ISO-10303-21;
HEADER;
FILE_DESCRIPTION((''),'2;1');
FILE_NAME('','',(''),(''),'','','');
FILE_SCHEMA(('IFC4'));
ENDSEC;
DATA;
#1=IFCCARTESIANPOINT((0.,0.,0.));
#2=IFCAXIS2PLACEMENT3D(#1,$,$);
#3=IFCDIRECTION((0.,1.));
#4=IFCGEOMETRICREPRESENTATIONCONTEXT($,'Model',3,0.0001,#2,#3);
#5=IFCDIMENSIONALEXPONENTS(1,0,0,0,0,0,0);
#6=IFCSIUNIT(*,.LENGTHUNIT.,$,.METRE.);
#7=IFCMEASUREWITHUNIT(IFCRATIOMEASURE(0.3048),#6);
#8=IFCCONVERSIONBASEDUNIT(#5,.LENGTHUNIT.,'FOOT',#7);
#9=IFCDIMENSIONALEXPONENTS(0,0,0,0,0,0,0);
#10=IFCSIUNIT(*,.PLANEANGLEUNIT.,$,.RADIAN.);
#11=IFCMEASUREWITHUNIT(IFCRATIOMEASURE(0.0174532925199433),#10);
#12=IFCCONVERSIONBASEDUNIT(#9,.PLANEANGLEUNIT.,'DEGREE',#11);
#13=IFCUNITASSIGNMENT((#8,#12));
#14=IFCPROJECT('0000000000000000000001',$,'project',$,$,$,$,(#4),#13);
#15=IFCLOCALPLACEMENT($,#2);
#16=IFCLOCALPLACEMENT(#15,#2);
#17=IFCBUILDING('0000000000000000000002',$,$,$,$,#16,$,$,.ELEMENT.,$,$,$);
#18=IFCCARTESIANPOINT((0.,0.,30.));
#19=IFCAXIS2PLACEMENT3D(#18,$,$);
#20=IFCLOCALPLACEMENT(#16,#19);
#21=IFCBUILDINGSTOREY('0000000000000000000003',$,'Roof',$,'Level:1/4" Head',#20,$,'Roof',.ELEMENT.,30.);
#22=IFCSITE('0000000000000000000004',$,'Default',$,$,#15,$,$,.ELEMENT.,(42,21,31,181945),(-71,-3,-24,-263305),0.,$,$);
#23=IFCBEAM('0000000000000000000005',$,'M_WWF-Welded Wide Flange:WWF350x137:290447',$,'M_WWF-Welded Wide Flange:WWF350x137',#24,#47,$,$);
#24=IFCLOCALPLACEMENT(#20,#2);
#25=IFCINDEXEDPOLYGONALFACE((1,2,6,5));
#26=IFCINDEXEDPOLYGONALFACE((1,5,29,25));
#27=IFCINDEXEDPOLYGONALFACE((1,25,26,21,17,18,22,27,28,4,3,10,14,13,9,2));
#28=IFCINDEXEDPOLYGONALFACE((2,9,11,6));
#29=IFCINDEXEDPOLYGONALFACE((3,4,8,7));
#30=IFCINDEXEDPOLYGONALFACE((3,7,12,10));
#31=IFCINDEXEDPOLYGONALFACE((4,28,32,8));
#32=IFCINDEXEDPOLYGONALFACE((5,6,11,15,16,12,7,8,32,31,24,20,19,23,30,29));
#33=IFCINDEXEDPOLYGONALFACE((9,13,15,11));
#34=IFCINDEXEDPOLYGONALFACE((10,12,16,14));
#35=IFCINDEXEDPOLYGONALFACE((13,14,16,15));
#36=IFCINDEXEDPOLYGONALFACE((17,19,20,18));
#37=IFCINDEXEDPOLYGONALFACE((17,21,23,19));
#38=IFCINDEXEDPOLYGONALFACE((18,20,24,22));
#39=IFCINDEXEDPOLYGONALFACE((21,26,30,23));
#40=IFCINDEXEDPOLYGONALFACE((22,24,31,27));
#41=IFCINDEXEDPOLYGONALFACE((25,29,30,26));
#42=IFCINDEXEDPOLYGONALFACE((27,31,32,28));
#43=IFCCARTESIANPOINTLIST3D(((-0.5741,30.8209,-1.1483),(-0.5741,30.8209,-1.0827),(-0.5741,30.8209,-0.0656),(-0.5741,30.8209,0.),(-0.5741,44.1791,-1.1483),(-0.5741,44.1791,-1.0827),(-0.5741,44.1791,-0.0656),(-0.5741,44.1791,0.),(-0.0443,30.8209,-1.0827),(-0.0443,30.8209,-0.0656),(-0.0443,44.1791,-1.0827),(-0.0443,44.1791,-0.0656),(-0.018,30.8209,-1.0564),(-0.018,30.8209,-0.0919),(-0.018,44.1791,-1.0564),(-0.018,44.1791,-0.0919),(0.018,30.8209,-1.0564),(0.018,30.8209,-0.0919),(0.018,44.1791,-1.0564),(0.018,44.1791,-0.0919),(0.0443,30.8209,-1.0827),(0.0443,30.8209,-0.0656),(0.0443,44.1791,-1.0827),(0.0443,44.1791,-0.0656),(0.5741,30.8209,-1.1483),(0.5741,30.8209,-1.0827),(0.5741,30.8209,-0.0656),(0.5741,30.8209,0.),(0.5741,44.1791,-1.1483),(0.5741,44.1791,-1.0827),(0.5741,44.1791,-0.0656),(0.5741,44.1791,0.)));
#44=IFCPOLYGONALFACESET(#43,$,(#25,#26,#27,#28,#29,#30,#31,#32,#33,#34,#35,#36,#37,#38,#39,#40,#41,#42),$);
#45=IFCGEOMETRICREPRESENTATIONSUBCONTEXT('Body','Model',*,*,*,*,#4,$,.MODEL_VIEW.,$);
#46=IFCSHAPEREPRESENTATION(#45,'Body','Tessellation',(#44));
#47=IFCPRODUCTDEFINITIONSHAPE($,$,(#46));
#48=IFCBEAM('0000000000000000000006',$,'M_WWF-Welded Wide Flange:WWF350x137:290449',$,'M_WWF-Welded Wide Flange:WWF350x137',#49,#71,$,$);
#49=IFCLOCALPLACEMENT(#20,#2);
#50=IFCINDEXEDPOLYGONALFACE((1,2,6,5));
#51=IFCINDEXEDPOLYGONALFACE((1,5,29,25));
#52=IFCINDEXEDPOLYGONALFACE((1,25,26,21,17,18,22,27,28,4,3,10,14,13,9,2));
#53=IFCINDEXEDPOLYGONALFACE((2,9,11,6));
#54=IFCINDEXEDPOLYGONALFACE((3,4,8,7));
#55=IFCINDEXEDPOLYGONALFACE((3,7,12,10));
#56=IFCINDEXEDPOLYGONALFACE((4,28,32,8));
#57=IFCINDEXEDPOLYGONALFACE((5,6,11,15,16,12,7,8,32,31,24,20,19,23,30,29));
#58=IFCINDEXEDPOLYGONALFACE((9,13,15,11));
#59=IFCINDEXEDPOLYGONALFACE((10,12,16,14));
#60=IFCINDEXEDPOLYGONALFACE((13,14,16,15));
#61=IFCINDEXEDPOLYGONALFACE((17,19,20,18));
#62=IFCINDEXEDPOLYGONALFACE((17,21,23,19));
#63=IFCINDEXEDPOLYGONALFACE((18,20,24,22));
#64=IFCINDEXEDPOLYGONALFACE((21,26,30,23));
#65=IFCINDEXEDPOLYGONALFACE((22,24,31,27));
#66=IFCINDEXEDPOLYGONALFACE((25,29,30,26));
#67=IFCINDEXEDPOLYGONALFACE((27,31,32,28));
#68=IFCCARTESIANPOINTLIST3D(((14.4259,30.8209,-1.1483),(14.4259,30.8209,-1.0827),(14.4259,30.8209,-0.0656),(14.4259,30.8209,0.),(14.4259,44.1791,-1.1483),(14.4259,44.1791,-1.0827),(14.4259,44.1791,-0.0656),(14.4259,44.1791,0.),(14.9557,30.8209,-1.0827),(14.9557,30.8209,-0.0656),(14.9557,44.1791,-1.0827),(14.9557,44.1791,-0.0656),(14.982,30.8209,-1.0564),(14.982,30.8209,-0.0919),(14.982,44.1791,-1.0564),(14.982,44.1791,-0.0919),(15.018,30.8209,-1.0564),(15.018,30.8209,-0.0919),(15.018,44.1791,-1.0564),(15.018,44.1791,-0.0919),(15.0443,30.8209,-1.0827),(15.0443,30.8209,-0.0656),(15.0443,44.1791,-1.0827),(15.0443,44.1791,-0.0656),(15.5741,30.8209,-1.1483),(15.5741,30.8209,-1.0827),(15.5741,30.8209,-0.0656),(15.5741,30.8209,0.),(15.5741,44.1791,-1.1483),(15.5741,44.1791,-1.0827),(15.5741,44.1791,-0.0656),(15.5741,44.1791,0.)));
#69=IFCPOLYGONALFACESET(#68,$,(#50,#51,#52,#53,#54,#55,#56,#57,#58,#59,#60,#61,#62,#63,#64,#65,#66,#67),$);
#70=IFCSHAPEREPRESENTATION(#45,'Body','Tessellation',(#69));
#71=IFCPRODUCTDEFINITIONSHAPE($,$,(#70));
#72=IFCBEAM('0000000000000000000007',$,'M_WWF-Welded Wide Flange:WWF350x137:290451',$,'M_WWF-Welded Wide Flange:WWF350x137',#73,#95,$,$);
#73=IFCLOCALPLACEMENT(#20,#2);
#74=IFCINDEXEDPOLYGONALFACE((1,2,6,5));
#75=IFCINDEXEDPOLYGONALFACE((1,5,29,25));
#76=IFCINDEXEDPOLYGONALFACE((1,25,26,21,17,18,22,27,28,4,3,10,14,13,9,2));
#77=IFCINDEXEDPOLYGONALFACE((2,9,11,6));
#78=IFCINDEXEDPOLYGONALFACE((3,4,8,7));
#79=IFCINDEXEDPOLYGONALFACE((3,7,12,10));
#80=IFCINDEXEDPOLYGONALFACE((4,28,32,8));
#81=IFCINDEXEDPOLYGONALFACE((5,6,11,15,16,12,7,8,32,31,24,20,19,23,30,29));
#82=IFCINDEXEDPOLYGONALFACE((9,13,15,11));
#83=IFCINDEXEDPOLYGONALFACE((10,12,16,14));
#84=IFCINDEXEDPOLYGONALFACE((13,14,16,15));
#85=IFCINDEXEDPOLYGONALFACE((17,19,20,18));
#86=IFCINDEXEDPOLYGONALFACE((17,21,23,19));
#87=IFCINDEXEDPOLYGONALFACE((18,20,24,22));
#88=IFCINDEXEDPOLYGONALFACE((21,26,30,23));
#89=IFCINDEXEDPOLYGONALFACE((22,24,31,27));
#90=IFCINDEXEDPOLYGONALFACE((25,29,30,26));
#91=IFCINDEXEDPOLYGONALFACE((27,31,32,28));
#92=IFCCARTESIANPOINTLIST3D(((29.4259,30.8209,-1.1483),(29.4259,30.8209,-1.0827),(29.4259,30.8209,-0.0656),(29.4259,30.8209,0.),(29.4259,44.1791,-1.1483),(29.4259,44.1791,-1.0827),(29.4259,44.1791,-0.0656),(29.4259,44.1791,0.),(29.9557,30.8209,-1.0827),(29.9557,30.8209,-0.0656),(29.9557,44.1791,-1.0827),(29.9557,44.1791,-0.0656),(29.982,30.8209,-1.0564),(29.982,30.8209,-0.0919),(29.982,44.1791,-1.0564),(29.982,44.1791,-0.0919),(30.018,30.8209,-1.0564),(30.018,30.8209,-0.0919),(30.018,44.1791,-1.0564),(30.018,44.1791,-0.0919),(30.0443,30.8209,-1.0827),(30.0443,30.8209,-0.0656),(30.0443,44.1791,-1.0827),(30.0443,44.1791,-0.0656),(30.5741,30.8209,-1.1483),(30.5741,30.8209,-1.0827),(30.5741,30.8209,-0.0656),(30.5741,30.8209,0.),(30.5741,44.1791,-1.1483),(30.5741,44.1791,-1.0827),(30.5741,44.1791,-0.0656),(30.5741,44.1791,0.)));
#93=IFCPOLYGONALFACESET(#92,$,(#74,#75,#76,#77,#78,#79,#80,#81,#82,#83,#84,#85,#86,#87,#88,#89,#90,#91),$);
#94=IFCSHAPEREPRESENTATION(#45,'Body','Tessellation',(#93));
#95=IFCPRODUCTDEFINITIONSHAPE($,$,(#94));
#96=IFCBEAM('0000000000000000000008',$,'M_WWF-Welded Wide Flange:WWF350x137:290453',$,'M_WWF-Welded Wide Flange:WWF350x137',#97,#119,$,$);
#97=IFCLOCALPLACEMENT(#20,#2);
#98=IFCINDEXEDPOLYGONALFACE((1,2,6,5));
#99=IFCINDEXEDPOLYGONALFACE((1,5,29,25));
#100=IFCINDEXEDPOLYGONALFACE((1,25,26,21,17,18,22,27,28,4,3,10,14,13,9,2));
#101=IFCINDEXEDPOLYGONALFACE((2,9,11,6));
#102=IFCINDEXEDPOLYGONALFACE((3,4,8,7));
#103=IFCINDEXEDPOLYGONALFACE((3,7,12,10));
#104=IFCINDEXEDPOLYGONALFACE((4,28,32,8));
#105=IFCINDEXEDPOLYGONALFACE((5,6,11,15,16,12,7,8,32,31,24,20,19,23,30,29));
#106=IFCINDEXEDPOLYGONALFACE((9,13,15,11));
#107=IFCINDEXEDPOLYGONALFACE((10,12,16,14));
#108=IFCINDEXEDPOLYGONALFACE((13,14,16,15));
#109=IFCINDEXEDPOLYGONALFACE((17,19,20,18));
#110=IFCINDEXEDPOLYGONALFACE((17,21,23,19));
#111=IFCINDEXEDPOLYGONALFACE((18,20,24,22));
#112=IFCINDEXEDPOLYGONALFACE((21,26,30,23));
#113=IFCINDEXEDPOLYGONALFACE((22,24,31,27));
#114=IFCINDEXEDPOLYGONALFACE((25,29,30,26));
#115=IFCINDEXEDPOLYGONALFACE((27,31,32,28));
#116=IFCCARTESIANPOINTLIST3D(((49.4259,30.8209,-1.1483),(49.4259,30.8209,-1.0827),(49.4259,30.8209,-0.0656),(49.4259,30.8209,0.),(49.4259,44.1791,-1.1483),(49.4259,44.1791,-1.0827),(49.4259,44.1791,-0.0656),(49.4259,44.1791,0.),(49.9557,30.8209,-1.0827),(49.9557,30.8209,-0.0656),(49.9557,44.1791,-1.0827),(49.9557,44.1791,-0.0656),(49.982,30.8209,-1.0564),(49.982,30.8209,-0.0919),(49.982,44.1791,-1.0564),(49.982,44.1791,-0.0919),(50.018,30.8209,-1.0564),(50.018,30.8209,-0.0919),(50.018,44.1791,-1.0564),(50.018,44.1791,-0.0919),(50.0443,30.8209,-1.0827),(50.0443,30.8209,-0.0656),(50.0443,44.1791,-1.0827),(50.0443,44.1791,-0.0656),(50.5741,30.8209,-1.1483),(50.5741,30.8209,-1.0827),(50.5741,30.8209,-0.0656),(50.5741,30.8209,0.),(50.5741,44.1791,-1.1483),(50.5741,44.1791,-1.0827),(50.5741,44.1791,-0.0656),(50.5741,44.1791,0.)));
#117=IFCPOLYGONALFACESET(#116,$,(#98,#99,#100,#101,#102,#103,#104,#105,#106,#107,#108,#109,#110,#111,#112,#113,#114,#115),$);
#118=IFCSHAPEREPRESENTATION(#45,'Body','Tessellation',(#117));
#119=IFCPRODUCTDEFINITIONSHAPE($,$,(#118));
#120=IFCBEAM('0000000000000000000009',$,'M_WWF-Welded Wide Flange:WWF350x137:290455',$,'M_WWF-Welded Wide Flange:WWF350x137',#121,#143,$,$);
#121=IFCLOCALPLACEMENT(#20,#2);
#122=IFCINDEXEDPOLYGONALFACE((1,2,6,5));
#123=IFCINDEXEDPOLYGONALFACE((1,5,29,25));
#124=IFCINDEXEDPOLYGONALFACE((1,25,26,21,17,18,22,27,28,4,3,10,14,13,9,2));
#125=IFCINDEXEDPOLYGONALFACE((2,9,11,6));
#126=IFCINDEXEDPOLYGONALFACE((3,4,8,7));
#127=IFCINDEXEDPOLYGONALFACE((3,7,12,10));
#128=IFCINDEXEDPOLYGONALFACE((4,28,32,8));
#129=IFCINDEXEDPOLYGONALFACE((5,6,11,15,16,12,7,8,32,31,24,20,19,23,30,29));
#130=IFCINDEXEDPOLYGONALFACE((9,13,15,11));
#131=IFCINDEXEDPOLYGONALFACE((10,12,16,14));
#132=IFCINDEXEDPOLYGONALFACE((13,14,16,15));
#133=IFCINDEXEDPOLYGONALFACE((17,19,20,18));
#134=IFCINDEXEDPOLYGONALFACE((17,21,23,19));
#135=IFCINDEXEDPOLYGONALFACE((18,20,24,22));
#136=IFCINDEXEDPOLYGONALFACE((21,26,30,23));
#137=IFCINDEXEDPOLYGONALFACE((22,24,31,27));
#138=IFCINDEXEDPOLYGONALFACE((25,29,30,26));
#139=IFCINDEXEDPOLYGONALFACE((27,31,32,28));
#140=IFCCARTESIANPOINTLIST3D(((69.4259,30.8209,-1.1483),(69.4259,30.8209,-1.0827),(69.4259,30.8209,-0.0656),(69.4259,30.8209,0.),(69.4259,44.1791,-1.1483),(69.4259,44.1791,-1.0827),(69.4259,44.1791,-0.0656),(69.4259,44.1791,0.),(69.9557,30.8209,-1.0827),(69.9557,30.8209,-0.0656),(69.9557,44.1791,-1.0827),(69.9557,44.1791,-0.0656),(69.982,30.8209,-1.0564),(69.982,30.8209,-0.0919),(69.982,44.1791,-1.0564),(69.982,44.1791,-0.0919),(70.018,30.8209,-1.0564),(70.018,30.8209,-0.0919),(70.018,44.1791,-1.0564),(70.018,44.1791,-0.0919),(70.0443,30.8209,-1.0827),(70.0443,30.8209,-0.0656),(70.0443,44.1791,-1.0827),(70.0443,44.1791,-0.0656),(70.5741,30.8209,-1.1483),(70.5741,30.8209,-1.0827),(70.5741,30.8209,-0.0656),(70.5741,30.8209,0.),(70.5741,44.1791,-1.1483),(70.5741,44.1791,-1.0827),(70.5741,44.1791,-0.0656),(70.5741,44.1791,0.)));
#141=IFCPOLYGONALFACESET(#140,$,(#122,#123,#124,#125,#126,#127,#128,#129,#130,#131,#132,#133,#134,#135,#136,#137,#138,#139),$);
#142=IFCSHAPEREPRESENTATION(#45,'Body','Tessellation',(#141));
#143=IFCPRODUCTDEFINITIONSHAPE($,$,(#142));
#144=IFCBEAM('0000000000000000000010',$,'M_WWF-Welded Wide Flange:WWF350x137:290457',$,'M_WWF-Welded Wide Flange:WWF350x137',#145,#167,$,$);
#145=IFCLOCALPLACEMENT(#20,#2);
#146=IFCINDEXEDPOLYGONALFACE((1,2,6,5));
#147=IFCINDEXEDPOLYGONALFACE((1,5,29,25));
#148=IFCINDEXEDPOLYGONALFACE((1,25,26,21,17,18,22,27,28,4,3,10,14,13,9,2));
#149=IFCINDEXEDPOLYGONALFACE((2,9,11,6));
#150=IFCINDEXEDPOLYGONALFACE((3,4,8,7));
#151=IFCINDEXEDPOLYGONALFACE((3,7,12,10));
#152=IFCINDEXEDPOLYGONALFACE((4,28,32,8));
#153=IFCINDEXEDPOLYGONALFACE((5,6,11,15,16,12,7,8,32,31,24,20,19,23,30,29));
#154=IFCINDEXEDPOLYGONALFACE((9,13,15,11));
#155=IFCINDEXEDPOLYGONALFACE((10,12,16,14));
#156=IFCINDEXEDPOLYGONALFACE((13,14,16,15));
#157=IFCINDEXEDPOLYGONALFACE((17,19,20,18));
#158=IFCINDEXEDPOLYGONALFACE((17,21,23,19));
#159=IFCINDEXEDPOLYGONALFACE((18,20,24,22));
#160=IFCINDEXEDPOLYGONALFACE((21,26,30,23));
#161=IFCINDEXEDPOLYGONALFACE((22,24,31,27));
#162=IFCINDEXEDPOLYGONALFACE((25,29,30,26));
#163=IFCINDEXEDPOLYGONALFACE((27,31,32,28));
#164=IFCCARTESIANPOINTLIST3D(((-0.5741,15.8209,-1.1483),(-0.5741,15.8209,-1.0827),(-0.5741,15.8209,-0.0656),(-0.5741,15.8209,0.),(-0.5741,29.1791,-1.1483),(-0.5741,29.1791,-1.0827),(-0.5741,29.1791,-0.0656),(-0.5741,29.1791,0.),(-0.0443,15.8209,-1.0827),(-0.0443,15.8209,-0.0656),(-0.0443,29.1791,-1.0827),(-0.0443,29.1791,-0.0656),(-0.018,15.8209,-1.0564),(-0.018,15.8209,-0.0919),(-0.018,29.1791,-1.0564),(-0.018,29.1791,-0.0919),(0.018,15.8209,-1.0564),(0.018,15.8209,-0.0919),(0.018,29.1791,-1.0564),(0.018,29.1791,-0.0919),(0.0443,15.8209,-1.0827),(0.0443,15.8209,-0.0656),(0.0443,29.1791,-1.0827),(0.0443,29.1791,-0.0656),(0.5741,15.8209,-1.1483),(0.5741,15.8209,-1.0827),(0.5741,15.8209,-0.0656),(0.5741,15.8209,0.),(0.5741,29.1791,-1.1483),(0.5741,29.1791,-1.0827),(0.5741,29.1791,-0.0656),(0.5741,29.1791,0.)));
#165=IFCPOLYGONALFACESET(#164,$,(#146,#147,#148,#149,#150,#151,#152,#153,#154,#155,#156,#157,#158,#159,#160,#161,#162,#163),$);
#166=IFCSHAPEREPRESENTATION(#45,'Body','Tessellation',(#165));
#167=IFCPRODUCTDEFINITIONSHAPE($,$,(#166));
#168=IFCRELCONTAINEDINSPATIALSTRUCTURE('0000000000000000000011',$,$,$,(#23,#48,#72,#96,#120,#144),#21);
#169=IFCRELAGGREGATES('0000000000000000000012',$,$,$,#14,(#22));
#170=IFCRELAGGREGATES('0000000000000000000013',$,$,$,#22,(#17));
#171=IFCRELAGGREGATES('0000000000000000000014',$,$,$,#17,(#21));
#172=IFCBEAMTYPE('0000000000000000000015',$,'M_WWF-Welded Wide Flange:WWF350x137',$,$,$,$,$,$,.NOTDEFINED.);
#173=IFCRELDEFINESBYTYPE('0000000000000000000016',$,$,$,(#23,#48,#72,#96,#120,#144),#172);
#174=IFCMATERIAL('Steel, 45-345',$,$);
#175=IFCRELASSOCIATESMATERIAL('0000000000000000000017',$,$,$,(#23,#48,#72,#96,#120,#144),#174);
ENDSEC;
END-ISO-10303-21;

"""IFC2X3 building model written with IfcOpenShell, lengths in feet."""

from ifc_helpers import new_model, entity, si_unit, converted_unit, direction, frame, origin, place, context, subcontext, project, spatial, polyline, outline, extrude, material, type_object, element, save


model = new_model("IFC2X3")

# Units and contexts
model_context = context("Model", 3, precision=0.0001, world=origin(), true_north=direction((0.0, 1.0)))
body_context = subcontext(model_context, "Body", "Model", "MODEL_VIEW")
ifc_project = project(units=[converted_unit("LENGTHUNIT", "FOOT", entity("IfcRatioMeasure", 0.3048), si_unit("LENGTHUNIT", "METRE"), dimensions=[1, 0, 0, 0, 0, 0, 0]), converted_unit("PLANEANGLEUNIT", "DEGREE", entity("IfcRatioMeasure", 0.0174532925199433), si_unit("PLANEANGLEUNIT", "RADIAN"), dimensions=[0, 0, 0, 0, 0, 0, 0])], contexts=[model_context])

# Site, building, storey
site_placement = place(None, origin())
site = spatial("IfcSite", under=ifc_project, at=site_placement, Name="Default", CompositionType="ELEMENT", RefLatitude=(42, 21, 31, 181945), RefLongitude=(-71, -3, -24, -263305), RefElevation=0.0)
building_placement = place(site_placement, origin())
building = spatial("IfcBuilding", under=site, at=building_placement, CompositionType="ELEMENT")
storey_placement = place(building_placement, frame((0.0, 0.0, 30.0)))
storey = spatial("IfcBuildingStorey", under=building, at=storey_placement, Name="Roof", ObjectType="Level:1/4\" Head", LongName="Roof", CompositionType="ELEMENT", Elevation=30.0)

# Beams
ifc_material = material(Name="Steel, 45-345")
beam_type = type_object("IfcBeamType", Name="M_WWF-Welded Wide Flange:WWF350x137", PredefinedType="NOTDEFINED")
beam_1_placement = place(storey_placement, frame((0.0, 30.0, 0.0), z_axis=(0.0, 0.0, 1.0), x_axis=(0.0, 1.0, 0.0)))
element("IfcBeam", 1, at=beam_1_placement, inside=storey, type_object=beam_type, material=ifc_material, Name="M_WWF-Welded Wide Flange:WWF350x137:290447", ObjectType="M_WWF-Welded Wide Flange:WWF350x137", context=body_context, shape_type="SweptSolid", body=[
    extrude(outline(polyline([(-0.5741, -0.5741), (-0.5085, -0.5741), (-0.5085, -0.0443), (-0.4823, -0.018), (0.4823, -0.018), (0.5085, -0.0443), (0.5085, -0.5741), (0.5741, -0.5741), (0.5741, 0.5741), (0.5085, 0.5741), (0.5085, 0.0443), (0.4823, 0.018), (-0.4823, 0.018), (-0.5085, 0.0443), (-0.5085, 0.5741), (-0.5741, 0.5741), (-0.5741, -0.5741)])), frame((0.8209, 0.0, -0.5741), z_axis=(1.0, 0.0, 0.0), x_axis=(0.0, 0.0, -1.0)), (0.0, 0.0, 1.0), 13.3583),
])
beam_2_placement = place(storey_placement, frame((15.0, 30.0, 0.0), z_axis=(0.0, 0.0, 1.0), x_axis=(0.0, 1.0, 0.0)))
element("IfcBeam", 2, at=beam_2_placement, inside=storey, type_object=beam_type, material=ifc_material, Name="M_WWF-Welded Wide Flange:WWF350x137:290449", ObjectType="M_WWF-Welded Wide Flange:WWF350x137", context=body_context, shape_type="SweptSolid", body=[
    extrude(outline(polyline([(-0.5741, -0.5741), (-0.5085, -0.5741), (-0.5085, -0.0443), (-0.4823, -0.018), (0.4823, -0.018), (0.5085, -0.0443), (0.5085, -0.5741), (0.5741, -0.5741), (0.5741, 0.5741), (0.5085, 0.5741), (0.5085, 0.0443), (0.4823, 0.018), (-0.4823, 0.018), (-0.5085, 0.0443), (-0.5085, 0.5741), (-0.5741, 0.5741), (-0.5741, -0.5741)])), frame((0.8209, 0.0, -0.5741), z_axis=(1.0, 0.0, 0.0), x_axis=(0.0, 0.0, -1.0)), (0.0, 0.0, 1.0), 13.3583),
])
beam_3_placement = place(storey_placement, frame((30.0, 30.0, 0.0), z_axis=(0.0, 0.0, 1.0), x_axis=(0.0, 1.0, 0.0)))
element("IfcBeam", 3, at=beam_3_placement, inside=storey, type_object=beam_type, material=ifc_material, Name="M_WWF-Welded Wide Flange:WWF350x137:290451", ObjectType="M_WWF-Welded Wide Flange:WWF350x137", context=body_context, shape_type="SweptSolid", body=[
    extrude(outline(polyline([(-0.5741, -0.5741), (-0.5085, -0.5741), (-0.5085, -0.0443), (-0.4823, -0.018), (0.4823, -0.018), (0.5085, -0.0443), (0.5085, -0.5741), (0.5741, -0.5741), (0.5741, 0.5741), (0.5085, 0.5741), (0.5085, 0.0443), (0.4823, 0.018), (-0.4823, 0.018), (-0.5085, 0.0443), (-0.5085, 0.5741), (-0.5741, 0.5741), (-0.5741, -0.5741)])), frame((0.8209, 0.0, -0.5741), z_axis=(1.0, 0.0, 0.0), x_axis=(0.0, 0.0, -1.0)), (0.0, 0.0, 1.0), 13.3583),
])
beam_4_placement = place(storey_placement, frame((50.0, 30.0, 0.0), z_axis=(0.0, 0.0, 1.0), x_axis=(0.0, 1.0, 0.0)))
element("IfcBeam", 4, at=beam_4_placement, inside=storey, type_object=beam_type, material=ifc_material, Name="M_WWF-Welded Wide Flange:WWF350x137:290453", ObjectType="M_WWF-Welded Wide Flange:WWF350x137", context=body_context, shape_type="SweptSolid", body=[
    extrude(outline(polyline([(-0.5741, -0.5741), (-0.5085, -0.5741), (-0.5085, -0.0443), (-0.4823, -0.018), (0.4823, -0.018), (0.5085, -0.0443), (0.5085, -0.5741), (0.5741, -0.5741), (0.5741, 0.5741), (0.5085, 0.5741), (0.5085, 0.0443), (0.4823, 0.018), (-0.4823, 0.018), (-0.5085, 0.0443), (-0.5085, 0.5741), (-0.5741, 0.5741), (-0.5741, -0.5741)])), frame((0.8209, 0.0, -0.5741), z_axis=(1.0, 0.0, 0.0), x_axis=(0.0, 0.0, -1.0)), (0.0, 0.0, 1.0), 13.3583),
])
beam_5_placement = place(storey_placement, frame((70.0, 30.0, 0.0), z_axis=(0.0, 0.0, 1.0), x_axis=(0.0, 1.0, 0.0)))
element("IfcBeam", 5, at=beam_5_placement, inside=storey, type_object=beam_type, material=ifc_material, Name="M_WWF-Welded Wide Flange:WWF350x137:290455", ObjectType="M_WWF-Welded Wide Flange:WWF350x137", context=body_context, shape_type="SweptSolid", body=[
    extrude(outline(polyline([(-0.5741, -0.5741), (-0.5085, -0.5741), (-0.5085, -0.0443), (-0.4823, -0.018), (0.4823, -0.018), (0.5085, -0.0443), (0.5085, -0.5741), (0.5741, -0.5741), (0.5741, 0.5741), (0.5085, 0.5741), (0.5085, 0.0443), (0.4823, 0.018), (-0.4823, 0.018), (-0.5085, 0.0443), (-0.5085, 0.5741), (-0.5741, 0.5741), (-0.5741, -0.5741)])), frame((0.8209, 0.0, -0.5741), z_axis=(1.0, 0.0, 0.0), x_axis=(0.0, 0.0, -1.0)), (0.0, 0.0, 1.0), 13.3583),
])
beam_6_placement = place(storey_placement, frame((0.0, 15.0, 0.0), z_axis=(0.0, 0.0, 1.0), x_axis=(0.0, 1.0, 0.0)))
element("IfcBeam", 6, at=beam_6_placement, inside=storey, type_object=beam_type, material=ifc_material, Name="M_WWF-Welded Wide Flange:WWF350x137:290457", ObjectType="M_WWF-Welded Wide Flange:WWF350x137", context=body_context, shape_type="SweptSolid", body=[
    extrude(outline(polyline([(-0.5741, -0.5741), (-0.5085, -0.5741), (-0.5085, -0.0443), (-0.4823, -0.018), (0.4823, -0.018), (0.5085, -0.0443), (0.5085, -0.5741), (0.5741, -0.5741), (0.5741, 0.5741), (0.5085, 0.5741), (0.5085, 0.0443), (0.4823, 0.018), (-0.4823, 0.018), (-0.5085, 0.0443), (-0.5085, 0.5741), (-0.5741, 0.5741), (-0.5741, -0.5741)])), frame((0.8209, 0.0, -0.5741), z_axis=(1.0, 0.0, 0.0), x_axis=(0.0, 0.0, -1.0)), (0.0, 0.0, 1.0), 13.3583),
])

save(model, "model.ifc")
